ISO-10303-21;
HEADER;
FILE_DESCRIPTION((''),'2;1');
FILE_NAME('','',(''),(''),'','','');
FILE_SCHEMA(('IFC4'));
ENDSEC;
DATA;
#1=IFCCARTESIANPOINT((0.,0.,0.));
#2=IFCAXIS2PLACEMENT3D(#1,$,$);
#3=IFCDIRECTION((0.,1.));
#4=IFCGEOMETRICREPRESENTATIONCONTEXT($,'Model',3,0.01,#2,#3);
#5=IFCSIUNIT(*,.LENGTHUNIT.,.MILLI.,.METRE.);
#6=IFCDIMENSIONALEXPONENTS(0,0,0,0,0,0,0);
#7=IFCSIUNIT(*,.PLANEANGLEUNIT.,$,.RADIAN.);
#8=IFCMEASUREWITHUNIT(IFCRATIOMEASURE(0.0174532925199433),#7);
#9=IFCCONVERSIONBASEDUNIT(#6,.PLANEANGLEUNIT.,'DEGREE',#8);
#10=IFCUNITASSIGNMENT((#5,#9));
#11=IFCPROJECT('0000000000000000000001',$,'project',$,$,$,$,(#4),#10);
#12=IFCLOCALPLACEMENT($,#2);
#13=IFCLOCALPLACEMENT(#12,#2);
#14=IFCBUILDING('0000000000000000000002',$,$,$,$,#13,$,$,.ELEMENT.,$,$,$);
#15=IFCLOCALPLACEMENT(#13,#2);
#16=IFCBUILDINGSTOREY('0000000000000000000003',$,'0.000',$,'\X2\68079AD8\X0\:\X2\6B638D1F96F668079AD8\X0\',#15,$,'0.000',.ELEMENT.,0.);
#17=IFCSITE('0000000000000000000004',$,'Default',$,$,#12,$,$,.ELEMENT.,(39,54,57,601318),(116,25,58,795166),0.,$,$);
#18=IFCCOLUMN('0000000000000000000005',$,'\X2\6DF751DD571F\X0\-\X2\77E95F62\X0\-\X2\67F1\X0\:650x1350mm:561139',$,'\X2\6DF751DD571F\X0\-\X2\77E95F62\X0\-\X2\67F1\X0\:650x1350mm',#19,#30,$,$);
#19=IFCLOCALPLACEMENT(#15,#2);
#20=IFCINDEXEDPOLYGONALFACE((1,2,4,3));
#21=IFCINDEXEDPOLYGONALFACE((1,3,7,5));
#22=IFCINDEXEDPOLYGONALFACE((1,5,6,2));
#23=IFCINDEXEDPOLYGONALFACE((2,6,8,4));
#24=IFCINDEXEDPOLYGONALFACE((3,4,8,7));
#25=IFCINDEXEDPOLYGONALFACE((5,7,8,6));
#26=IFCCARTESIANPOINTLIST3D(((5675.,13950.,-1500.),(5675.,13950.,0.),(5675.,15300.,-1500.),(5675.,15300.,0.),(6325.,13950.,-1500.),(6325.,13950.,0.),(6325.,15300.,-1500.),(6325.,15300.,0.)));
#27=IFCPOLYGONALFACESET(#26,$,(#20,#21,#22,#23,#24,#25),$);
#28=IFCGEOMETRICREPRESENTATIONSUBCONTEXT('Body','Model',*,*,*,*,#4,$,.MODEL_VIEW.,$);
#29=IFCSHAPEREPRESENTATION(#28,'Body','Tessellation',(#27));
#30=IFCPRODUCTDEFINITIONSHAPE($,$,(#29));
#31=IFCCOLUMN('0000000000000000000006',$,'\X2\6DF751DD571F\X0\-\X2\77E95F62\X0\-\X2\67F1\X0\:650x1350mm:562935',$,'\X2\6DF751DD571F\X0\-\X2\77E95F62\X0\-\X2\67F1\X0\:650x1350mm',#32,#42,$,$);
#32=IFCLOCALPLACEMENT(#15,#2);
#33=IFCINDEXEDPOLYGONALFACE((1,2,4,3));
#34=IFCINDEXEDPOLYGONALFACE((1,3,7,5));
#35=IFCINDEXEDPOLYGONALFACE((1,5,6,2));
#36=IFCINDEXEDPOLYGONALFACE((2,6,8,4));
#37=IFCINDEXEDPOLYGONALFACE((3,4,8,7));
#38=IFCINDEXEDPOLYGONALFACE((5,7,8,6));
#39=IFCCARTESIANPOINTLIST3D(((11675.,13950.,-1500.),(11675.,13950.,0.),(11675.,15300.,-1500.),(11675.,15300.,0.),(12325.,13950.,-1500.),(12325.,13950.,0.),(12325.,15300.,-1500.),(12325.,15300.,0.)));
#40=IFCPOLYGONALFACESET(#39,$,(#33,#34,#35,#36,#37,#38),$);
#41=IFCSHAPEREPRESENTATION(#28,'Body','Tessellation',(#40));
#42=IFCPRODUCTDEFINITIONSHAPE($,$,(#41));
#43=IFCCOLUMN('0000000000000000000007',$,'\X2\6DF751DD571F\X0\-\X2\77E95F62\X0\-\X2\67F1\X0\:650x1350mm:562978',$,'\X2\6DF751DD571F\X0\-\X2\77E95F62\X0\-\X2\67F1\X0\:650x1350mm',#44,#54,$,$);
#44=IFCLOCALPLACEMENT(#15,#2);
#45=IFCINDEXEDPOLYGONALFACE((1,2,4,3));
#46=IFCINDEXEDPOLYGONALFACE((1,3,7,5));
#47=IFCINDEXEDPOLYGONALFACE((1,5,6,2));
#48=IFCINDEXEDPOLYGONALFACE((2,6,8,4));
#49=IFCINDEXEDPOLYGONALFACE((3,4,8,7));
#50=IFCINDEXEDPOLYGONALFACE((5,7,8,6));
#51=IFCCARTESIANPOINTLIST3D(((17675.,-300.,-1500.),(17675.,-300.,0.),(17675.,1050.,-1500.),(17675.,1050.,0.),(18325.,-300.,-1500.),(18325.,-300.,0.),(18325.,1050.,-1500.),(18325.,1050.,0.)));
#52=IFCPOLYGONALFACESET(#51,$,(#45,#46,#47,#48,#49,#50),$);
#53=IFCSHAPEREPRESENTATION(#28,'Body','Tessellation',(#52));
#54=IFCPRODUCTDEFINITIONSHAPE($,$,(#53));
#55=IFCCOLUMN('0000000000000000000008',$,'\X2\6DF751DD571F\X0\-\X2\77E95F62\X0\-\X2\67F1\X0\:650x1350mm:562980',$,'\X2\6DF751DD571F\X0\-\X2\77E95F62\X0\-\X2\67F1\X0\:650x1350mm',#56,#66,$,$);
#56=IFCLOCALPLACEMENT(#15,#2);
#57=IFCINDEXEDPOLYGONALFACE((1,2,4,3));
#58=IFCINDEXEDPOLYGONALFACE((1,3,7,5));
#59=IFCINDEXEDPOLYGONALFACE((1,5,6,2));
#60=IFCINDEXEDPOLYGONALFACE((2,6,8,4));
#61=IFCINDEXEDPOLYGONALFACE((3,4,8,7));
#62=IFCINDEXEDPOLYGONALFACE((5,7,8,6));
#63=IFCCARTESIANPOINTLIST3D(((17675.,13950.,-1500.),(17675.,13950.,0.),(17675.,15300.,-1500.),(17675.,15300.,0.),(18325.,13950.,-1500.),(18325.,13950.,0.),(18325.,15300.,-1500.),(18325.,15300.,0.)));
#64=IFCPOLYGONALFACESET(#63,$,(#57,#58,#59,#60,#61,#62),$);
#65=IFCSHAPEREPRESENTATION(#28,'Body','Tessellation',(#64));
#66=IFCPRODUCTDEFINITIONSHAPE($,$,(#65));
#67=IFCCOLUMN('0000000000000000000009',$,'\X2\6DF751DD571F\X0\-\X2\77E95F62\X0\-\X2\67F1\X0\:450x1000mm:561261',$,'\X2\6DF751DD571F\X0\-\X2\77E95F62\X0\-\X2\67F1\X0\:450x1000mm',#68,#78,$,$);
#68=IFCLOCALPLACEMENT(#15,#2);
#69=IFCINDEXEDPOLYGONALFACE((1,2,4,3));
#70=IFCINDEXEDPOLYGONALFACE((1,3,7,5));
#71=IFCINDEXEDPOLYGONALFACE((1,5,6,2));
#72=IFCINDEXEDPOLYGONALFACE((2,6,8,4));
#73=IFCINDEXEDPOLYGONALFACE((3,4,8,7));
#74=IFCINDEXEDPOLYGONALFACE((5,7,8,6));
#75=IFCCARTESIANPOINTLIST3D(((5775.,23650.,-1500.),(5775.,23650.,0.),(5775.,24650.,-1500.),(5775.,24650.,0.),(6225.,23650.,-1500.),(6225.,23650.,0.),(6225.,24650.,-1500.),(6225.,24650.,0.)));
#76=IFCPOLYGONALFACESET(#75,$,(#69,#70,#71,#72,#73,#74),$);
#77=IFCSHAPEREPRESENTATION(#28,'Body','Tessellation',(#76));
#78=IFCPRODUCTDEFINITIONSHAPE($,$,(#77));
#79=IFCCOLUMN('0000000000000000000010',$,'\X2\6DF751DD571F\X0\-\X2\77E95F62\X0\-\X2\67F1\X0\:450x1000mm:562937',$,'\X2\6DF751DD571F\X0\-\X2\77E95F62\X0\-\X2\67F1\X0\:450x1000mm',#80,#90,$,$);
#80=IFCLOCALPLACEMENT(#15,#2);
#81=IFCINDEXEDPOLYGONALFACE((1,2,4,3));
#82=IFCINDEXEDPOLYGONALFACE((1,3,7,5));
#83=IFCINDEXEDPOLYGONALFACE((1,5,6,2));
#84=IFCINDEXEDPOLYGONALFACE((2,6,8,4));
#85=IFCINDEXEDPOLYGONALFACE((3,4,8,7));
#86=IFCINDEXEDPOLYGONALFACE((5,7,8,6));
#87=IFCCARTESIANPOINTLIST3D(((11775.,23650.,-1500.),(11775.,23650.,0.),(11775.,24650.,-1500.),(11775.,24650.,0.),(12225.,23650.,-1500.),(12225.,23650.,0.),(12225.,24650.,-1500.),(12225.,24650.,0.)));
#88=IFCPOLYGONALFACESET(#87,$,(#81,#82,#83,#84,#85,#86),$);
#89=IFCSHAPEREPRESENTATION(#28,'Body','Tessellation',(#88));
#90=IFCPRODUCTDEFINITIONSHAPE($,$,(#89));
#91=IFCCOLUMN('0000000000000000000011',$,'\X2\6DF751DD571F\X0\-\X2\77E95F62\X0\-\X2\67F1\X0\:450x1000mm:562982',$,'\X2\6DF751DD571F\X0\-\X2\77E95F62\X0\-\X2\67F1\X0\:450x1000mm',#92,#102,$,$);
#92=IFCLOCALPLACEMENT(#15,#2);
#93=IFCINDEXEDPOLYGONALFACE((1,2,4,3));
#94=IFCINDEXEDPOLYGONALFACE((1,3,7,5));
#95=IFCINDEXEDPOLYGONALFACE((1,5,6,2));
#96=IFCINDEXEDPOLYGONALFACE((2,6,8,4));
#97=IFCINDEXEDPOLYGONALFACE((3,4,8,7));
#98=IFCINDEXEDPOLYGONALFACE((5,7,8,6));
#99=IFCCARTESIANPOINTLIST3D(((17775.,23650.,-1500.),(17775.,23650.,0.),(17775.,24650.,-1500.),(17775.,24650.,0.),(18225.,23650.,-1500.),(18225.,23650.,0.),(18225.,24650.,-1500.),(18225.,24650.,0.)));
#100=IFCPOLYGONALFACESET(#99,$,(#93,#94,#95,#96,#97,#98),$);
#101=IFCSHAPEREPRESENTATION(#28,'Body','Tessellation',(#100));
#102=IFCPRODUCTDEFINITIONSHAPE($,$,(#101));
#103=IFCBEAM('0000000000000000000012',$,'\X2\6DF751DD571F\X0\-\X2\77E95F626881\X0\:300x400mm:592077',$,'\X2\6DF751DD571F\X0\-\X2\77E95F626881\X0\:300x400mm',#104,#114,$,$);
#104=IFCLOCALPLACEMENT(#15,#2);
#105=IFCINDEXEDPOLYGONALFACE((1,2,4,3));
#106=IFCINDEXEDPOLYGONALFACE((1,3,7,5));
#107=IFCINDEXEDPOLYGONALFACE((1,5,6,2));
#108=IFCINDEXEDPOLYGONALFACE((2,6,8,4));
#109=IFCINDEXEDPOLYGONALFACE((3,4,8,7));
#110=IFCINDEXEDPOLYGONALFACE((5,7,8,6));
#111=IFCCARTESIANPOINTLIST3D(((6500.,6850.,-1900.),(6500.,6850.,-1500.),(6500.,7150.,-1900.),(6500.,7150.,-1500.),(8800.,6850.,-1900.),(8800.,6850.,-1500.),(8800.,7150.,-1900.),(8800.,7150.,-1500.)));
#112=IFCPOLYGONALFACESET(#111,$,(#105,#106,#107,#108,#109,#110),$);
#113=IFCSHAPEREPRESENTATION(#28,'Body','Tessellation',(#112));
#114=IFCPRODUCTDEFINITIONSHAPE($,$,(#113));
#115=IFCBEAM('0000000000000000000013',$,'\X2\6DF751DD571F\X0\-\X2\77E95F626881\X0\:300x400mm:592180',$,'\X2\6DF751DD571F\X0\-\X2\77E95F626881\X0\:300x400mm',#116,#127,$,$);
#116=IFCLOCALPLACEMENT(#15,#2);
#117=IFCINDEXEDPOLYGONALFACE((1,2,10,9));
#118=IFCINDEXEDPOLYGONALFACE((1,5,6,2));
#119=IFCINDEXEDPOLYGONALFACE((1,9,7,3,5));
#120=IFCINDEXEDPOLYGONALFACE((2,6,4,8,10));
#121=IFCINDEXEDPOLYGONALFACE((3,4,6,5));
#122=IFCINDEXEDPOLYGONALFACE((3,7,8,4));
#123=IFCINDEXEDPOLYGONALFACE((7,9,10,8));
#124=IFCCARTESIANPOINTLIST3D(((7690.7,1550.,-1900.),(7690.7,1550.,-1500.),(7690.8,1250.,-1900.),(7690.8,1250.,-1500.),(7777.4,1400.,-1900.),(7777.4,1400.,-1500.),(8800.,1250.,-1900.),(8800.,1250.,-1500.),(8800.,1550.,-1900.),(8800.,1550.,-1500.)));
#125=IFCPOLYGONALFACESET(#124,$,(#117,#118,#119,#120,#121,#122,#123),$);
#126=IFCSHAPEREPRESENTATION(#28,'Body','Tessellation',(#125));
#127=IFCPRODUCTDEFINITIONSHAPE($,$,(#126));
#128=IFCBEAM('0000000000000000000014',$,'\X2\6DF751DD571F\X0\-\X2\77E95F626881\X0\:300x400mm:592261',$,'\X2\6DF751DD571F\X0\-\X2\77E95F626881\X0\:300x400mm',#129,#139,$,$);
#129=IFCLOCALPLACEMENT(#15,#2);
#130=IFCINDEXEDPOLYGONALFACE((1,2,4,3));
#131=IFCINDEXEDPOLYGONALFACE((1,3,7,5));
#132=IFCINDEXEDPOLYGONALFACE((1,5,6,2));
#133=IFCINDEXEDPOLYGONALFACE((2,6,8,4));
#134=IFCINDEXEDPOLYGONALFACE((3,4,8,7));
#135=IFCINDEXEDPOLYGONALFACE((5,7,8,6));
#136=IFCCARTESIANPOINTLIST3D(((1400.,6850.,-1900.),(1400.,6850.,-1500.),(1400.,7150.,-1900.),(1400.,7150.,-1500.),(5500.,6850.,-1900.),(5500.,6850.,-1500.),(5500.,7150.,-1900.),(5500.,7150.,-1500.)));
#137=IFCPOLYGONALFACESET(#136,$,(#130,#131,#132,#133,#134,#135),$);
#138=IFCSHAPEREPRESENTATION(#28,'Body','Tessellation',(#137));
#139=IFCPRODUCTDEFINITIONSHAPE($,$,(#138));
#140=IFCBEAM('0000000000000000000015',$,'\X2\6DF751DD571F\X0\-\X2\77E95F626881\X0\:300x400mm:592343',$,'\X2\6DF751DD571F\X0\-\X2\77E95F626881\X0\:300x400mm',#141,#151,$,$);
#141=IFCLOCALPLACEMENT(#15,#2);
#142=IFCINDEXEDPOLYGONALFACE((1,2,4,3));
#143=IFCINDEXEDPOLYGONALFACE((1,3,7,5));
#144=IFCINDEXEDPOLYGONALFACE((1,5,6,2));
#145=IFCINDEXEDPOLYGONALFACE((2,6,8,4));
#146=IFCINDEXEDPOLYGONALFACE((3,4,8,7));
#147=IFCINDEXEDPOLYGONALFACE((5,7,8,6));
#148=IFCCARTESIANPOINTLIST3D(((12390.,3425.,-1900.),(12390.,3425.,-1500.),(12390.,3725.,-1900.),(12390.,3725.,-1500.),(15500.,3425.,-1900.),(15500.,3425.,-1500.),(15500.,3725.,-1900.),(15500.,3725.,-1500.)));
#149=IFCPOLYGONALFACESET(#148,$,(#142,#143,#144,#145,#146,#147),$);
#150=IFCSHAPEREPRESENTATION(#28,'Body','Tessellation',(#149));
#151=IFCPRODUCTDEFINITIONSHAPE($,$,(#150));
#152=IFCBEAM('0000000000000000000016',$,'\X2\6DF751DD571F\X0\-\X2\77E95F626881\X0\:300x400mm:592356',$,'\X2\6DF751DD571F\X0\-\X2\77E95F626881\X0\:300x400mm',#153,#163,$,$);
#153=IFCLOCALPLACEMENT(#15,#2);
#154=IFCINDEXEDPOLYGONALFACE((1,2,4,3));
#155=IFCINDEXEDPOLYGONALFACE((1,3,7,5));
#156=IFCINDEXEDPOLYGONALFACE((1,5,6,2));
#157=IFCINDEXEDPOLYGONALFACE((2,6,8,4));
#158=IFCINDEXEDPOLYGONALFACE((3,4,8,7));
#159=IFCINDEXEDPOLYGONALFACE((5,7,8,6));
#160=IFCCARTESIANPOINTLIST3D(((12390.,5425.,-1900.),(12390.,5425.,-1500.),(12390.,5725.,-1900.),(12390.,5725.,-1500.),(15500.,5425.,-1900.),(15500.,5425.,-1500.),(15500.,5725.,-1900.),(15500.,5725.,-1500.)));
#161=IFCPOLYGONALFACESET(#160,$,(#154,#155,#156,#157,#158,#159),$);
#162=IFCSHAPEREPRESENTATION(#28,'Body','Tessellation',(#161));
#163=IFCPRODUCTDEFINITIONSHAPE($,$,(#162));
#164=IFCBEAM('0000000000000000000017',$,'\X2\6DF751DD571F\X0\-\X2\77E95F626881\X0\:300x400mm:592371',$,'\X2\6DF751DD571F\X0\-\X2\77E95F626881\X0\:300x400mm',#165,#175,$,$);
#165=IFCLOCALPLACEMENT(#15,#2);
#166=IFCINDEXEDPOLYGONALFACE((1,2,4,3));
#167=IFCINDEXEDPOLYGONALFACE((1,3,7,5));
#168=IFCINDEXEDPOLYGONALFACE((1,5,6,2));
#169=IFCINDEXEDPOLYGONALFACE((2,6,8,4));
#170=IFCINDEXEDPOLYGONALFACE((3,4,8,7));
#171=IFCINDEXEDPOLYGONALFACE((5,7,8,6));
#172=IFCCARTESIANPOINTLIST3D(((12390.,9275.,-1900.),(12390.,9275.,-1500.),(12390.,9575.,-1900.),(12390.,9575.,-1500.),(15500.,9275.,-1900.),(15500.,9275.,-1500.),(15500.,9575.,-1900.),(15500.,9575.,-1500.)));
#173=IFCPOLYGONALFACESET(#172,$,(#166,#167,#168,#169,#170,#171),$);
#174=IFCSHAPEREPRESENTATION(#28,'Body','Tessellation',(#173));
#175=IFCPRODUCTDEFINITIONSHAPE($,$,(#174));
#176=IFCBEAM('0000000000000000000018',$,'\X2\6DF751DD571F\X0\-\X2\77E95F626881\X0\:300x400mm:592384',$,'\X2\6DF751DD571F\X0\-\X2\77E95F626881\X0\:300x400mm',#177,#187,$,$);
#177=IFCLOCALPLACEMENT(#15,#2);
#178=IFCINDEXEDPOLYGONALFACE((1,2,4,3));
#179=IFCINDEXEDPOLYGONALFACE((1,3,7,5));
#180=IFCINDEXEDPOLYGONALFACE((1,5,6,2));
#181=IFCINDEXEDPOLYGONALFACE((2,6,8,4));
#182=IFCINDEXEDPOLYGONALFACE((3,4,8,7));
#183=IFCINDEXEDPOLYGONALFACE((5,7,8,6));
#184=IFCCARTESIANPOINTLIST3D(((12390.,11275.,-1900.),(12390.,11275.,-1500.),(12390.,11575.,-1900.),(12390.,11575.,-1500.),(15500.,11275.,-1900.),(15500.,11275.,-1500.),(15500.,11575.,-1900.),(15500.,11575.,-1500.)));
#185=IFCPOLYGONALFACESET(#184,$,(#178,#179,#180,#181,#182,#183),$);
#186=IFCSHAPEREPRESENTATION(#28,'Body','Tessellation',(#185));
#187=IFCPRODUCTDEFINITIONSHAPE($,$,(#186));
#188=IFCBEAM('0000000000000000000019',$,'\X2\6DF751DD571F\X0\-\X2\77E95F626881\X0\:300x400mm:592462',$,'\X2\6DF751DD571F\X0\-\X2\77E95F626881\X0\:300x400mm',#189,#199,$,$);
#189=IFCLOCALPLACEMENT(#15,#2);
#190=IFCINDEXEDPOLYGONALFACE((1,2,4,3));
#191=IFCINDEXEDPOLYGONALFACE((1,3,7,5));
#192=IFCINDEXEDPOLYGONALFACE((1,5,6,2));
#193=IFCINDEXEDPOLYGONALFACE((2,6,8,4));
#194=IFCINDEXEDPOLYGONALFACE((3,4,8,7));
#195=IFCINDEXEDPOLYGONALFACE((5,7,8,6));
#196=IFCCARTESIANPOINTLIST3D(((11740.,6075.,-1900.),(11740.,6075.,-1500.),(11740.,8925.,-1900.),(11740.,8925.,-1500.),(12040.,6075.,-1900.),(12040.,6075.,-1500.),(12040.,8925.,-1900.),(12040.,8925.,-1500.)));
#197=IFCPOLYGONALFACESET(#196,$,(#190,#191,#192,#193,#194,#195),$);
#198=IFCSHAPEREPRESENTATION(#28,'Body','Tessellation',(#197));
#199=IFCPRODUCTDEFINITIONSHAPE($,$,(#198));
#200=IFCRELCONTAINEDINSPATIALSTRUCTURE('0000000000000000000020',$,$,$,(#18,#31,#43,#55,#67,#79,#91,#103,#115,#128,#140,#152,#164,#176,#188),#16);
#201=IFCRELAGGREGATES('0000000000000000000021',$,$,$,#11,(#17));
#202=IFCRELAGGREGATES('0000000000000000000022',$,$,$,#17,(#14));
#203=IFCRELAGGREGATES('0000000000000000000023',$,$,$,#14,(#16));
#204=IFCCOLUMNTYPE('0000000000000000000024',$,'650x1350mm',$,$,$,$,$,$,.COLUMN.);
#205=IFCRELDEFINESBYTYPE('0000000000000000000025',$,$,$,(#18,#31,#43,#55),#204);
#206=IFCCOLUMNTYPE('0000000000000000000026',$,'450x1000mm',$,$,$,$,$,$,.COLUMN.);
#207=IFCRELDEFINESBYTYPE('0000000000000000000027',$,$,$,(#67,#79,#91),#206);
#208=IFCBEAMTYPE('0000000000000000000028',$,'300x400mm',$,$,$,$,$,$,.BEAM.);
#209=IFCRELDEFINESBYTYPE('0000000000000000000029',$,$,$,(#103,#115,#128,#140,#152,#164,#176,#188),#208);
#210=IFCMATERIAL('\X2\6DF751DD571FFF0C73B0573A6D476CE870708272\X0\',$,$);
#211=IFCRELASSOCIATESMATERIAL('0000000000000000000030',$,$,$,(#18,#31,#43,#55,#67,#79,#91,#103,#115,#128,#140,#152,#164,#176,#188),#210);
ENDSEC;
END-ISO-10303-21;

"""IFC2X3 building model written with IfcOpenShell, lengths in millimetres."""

from ifc_helpers import new_model, entity, si_unit, converted_unit, direction, frame, frame_2d, origin, origin_2d_with_axis, place, context, subcontext, project, spatial, polyline, rectangle, extrude, clip, bounded_halfspace, source, transform, mapped, material, type_object, type_shapes, element, save


model = new_model("IFC2X3")

# Units and contexts
model_context = context("Model", 3, precision=0.01, world=origin(), true_north=direction((0.0, 1.0)))
body_context = subcontext(model_context, "Body", "Model", "MODEL_VIEW")
ifc_project = project(units=[si_unit("LENGTHUNIT", "METRE", prefix="MILLI"), converted_unit("PLANEANGLEUNIT", "DEGREE", entity("IfcRatioMeasure", 0.0174532925199433), si_unit("PLANEANGLEUNIT", "RADIAN"), dimensions=[0, 0, 0, 0, 0, 0, 0])], contexts=[model_context])

# Site, building, storey
site_placement = place(None, origin())
site = spatial("IfcSite", under=ifc_project, at=site_placement, Name="Default", CompositionType="ELEMENT", RefLatitude=(39, 54, 57, 601318), RefLongitude=(116, 25, 58, 795166), RefElevation=0.0)
building_placement = place(site_placement, origin())
building = spatial("IfcBuilding", under=site, at=building_placement, CompositionType="ELEMENT")
storey_placement = place(building_placement, origin())
storey = spatial("IfcBuildingStorey", under=building, at=storey_placement, Name="0.000", ObjectType="标高:正负零标高", LongName="0.000", CompositionType="ELEMENT", Elevation=0.0)

# Columns
ifc_material = material(Name="混凝土，现场浇注灰色")
column_type_1 = type_object("IfcColumnType", Name="650x1350mm", PredefinedType="COLUMN")
shared_shape_1 = source(origin(), body_context, "Body", "SweptSolid", [
    extrude(rectangle(XDim=1350.0, YDim=650.0, at=origin_2d_with_axis()), frame((0.0, 0.0, -1500.0), z_axis=(0.0, 0.0, 1.0), x_axis=(0.0, -1.0, 0.0)), (0.0, 0.0, 1.0), 1500.0),
])
type_shapes(column_type_1, [shared_shape_1])
for number, where, name in (
    (1, (6000.0, 14625.0, 0.0), "混凝土-矩形-柱:650x1350mm:561139"),
    (2, (12000.0, 14625.0, 0.0), "混凝土-矩形-柱:650x1350mm:562935"),
    (3, (18000.0, 375.0, 0.0), "混凝土-矩形-柱:650x1350mm:562978"),
    (4, (18000.0, 14625.0, 0.0), "混凝土-矩形-柱:650x1350mm:562980"),
):
    element("IfcColumn", number, at=place(storey_placement, frame(where)), inside=storey, type_object=column_type_1, material=ifc_material, Name=name, ObjectType="混凝土-矩形-柱:650x1350mm", context=body_context, shape_type="MappedRepresentation", body=[
        mapped(shared_shape_1, transform((0.0, 0.0, 0.0), scale=1.0)),
    ])
column_type_2 = type_object("IfcColumnType", Name="450x1000mm", PredefinedType="COLUMN")
shared_shape_2 = source(origin(), body_context, "Body", "SweptSolid", [
    extrude(rectangle(XDim=1000.0, YDim=450.0, at=origin_2d_with_axis()), frame((0.0, 0.0, -1500.0), z_axis=(0.0, 0.0, 1.0), x_axis=(0.0, -1.0, 0.0)), (0.0, 0.0, 1.0), 1500.0),
])
type_shapes(column_type_2, [shared_shape_2])
for number, where, name in (
    (5, (6000.0, 24150.0, 0.0), "混凝土-矩形-柱:450x1000mm:561261"),
    (6, (12000.0, 24150.0, 0.0), "混凝土-矩形-柱:450x1000mm:562937"),
    (7, (18000.0, 24150.0, 0.0), "混凝土-矩形-柱:450x1000mm:562982"),
):
    element("IfcColumn", number, at=place(storey_placement, frame(where)), inside=storey, type_object=column_type_2, material=ifc_material, Name=name, ObjectType="混凝土-矩形-柱:450x1000mm", context=body_context, shape_type="MappedRepresentation", body=[
        mapped(shared_shape_2, transform((0.0, 0.0, 0.0), scale=1.0)),
    ])

# Beams
beam_type_1 = type_object("IfcBeamType", Name="300x400mm", PredefinedType="BEAM")
beam_1_placement = place(storey_placement, frame((8800.0, 7000.0, -1500.0), z_axis=(0.0, 0.0, 1.0), x_axis=(-1.0, 0.0, 0.0)))
element("IfcBeam", 8, at=beam_1_placement, inside=storey, type_object=beam_type_1, material=ifc_material, Name="混凝土-矩形梁:300x400mm:592077", ObjectType="混凝土-矩形梁:300x400mm", context=body_context, shape_type="SweptSolid", body=[
    extrude(rectangle(XDim=400.0, YDim=300.0, at=origin_2d_with_axis()), frame((0.0, 0.0, -200.0), z_axis=(1.0, 0.0, 0.0), x_axis=(0.0, 0.0, -1.0)), (0.0, 0.0, 1.0), 2300.0),
])
beam_2_placement = place(storey_placement, frame((8800.0, 1400.0, -1500.0), z_axis=(0.0, 0.0, 1.0), x_axis=(-1.0, 0.0, 0.0)))
element("IfcBeam", 9, at=beam_2_placement, inside=storey, type_object=beam_type_1, material=ifc_material, Name="混凝土-矩形梁:300x400mm:592180", ObjectType="混凝土-矩形梁:300x400mm", context=body_context, shape_type="Clipping", body=[
    clip(clip(extrude(rectangle(XDim=400.0, YDim=300.0, at=origin_2d_with_axis()), frame((0.0, 0.0, -200.0), z_axis=(1.0, 0.0, 0.0), x_axis=(0.0, 0.0, -1.0)), (0.0, 0.0, 1.0), 1109.3), bounded_halfspace(frame((1311.3, -500.0, 0.0), z_axis=(0.866025, 0.5, 0.0), x_axis=(0.0, 0.0, -1.0)), False, frame((0.0, 0.0, -200.0), z_axis=(1.0, 0.0, 0.0), x_axis=(0.0, 0.0, -1.0)), polyline([(200.0, 0.0), (-200.0, 0.0), (-200.0, -150.0), (200.0, -150.0), (200.0, 0.0)]))), bounded_halfspace(frame((1022.6, 0.0, 0.0), z_axis=(0.865977, -0.500083, 0.0), x_axis=(0.0, 0.0, -1.0)), False, frame((0.0, 0.0, -200.0), z_axis=(1.0, 0.0, 0.0), x_axis=(0.0, 0.0, -1.0)), polyline([(-200.0, 0.0), (200.0, 0.0), (200.0, 150.0), (-200.0, 150.0), (-200.0, 0.0)]))),
])
beam_3_placement = place(storey_placement, frame((5500.0, 7000.0, -1500.0), z_axis=(0.0, 0.0, 1.0), x_axis=(-1.0, 0.0, 0.0)))
element("IfcBeam", 10, at=beam_3_placement, inside=storey, type_object=beam_type_1, material=ifc_material, Name="混凝土-矩形梁:300x400mm:592261", ObjectType="混凝土-矩形梁:300x400mm", context=body_context, shape_type="SweptSolid", body=[
    extrude(rectangle(XDim=400.0, YDim=300.0, at=frame_2d((0.0, 0.0), x_axis=(1.0, 0.0))), frame((0.0, 0.0, -200.0), z_axis=(1.0, 0.0, 0.0), x_axis=(0.0, 0.0, -1.0)), (0.0, 0.0, 1.0), 4100.0),
])
beam_4_placement = place(storey_placement, frame((15500.0, 3575.0, -1500.0), z_axis=(0.0, 0.0, 1.0), x_axis=(-1.0, 0.0, 0.0)))
element("IfcBeam", 11, at=beam_4_placement, inside=storey, type_object=beam_type_1, material=ifc_material, Name="混凝土-矩形梁:300x400mm:592343", ObjectType="混凝土-矩形梁:300x400mm", context=body_context, shape_type="SweptSolid", body=[
    extrude(rectangle(XDim=400.0, YDim=300.0, at=frame_2d((0.0, 0.0), x_axis=(1.0, 0.0))), frame((0.0, 0.0, -200.0), z_axis=(1.0, 0.0, 0.0), x_axis=(0.0, 0.0, -1.0)), (0.0, 0.0, 1.0), 3110.0),
])
beam_5_placement = place(storey_placement, frame((15500.0, 5575.0, -1500.0), z_axis=(0.0, 0.0, 1.0), x_axis=(-1.0, 0.0, 0.0)))
element("IfcBeam", 12, at=beam_5_placement, inside=storey, type_object=beam_type_1, material=ifc_material, Name="混凝土-矩形梁:300x400mm:592356", ObjectType="混凝土-矩形梁:300x400mm", context=body_context, shape_type="SweptSolid", body=[
    extrude(rectangle(XDim=400.0, YDim=300.0, at=frame_2d((0.0, 0.0), x_axis=(1.0, 0.0))), frame((0.0, 0.0, -200.0), z_axis=(1.0, 0.0, 0.0), x_axis=(0.0, 0.0, -1.0)), (0.0, 0.0, 1.0), 3110.0),
])
beam_6_placement = place(storey_placement, frame((15500.0, 9425.0, -1500.0), z_axis=(0.0, 0.0, 1.0), x_axis=(-1.0, 0.0, 0.0)))
element("IfcBeam", 13, at=beam_6_placement, inside=storey, type_object=beam_type_1, material=ifc_material, Name="混凝土-矩形梁:300x400mm:592371", ObjectType="混凝土-矩形梁:300x400mm", context=body_context, shape_type="SweptSolid", body=[
    extrude(rectangle(XDim=400.0, YDim=300.0, at=frame_2d((0.0, 0.0), x_axis=(1.0, 0.0))), frame((0.0, 0.0, -200.0), z_axis=(1.0, 0.0, 0.0), x_axis=(0.0, 0.0, -1.0)), (0.0, 0.0, 1.0), 3110.0),
])
beam_7_placement = place(storey_placement, frame((15500.0, 11425.0, -1500.0), z_axis=(0.0, 0.0, 1.0), x_axis=(-1.0, 0.0, 0.0)))
element("IfcBeam", 14, at=beam_7_placement, inside=storey, type_object=beam_type_1, material=ifc_material, Name="混凝土-矩形梁:300x400mm:592384", ObjectType="混凝土-矩形梁:300x400mm", context=body_context, shape_type="SweptSolid", body=[
    extrude(rectangle(XDim=400.0, YDim=300.0, at=frame_2d((0.0, 0.0), x_axis=(1.0, 0.0))), frame((0.0, 0.0, -200.0), z_axis=(1.0, 0.0, 0.0), x_axis=(0.0, 0.0, -1.0)), (0.0, 0.0, 1.0), 3110.0),
])
for number, where, z_axis, x_axis, name in (
    (15, (11890.0, 8925.0, -1500.0), (0.0, 0.0, 1.0), (0.0, -1.0, 0.0), "混凝土-矩形梁:300x400mm:592462"),
):
    element("IfcBeam", number, at=place(storey_placement, frame(where, z_axis=z_axis, x_axis=x_axis)), inside=storey, type_object=beam_type_1, material=ifc_material, Name=name, ObjectType="混凝土-矩形梁:300x400mm", context=body_context, shape_type="SweptSolid", body=[
        extrude(rectangle(XDim=400.0, YDim=300.0, at=frame_2d((0.0, 0.0), x_axis=(1.0, 0.0))), frame((0.0, 0.0, -200.0), z_axis=(1.0, 0.0, 0.0), x_axis=(0.0, 0.0, -1.0)), (0.0, 0.0, 1.0), 2850.0),
    ])

save(model, "model.ifc")
